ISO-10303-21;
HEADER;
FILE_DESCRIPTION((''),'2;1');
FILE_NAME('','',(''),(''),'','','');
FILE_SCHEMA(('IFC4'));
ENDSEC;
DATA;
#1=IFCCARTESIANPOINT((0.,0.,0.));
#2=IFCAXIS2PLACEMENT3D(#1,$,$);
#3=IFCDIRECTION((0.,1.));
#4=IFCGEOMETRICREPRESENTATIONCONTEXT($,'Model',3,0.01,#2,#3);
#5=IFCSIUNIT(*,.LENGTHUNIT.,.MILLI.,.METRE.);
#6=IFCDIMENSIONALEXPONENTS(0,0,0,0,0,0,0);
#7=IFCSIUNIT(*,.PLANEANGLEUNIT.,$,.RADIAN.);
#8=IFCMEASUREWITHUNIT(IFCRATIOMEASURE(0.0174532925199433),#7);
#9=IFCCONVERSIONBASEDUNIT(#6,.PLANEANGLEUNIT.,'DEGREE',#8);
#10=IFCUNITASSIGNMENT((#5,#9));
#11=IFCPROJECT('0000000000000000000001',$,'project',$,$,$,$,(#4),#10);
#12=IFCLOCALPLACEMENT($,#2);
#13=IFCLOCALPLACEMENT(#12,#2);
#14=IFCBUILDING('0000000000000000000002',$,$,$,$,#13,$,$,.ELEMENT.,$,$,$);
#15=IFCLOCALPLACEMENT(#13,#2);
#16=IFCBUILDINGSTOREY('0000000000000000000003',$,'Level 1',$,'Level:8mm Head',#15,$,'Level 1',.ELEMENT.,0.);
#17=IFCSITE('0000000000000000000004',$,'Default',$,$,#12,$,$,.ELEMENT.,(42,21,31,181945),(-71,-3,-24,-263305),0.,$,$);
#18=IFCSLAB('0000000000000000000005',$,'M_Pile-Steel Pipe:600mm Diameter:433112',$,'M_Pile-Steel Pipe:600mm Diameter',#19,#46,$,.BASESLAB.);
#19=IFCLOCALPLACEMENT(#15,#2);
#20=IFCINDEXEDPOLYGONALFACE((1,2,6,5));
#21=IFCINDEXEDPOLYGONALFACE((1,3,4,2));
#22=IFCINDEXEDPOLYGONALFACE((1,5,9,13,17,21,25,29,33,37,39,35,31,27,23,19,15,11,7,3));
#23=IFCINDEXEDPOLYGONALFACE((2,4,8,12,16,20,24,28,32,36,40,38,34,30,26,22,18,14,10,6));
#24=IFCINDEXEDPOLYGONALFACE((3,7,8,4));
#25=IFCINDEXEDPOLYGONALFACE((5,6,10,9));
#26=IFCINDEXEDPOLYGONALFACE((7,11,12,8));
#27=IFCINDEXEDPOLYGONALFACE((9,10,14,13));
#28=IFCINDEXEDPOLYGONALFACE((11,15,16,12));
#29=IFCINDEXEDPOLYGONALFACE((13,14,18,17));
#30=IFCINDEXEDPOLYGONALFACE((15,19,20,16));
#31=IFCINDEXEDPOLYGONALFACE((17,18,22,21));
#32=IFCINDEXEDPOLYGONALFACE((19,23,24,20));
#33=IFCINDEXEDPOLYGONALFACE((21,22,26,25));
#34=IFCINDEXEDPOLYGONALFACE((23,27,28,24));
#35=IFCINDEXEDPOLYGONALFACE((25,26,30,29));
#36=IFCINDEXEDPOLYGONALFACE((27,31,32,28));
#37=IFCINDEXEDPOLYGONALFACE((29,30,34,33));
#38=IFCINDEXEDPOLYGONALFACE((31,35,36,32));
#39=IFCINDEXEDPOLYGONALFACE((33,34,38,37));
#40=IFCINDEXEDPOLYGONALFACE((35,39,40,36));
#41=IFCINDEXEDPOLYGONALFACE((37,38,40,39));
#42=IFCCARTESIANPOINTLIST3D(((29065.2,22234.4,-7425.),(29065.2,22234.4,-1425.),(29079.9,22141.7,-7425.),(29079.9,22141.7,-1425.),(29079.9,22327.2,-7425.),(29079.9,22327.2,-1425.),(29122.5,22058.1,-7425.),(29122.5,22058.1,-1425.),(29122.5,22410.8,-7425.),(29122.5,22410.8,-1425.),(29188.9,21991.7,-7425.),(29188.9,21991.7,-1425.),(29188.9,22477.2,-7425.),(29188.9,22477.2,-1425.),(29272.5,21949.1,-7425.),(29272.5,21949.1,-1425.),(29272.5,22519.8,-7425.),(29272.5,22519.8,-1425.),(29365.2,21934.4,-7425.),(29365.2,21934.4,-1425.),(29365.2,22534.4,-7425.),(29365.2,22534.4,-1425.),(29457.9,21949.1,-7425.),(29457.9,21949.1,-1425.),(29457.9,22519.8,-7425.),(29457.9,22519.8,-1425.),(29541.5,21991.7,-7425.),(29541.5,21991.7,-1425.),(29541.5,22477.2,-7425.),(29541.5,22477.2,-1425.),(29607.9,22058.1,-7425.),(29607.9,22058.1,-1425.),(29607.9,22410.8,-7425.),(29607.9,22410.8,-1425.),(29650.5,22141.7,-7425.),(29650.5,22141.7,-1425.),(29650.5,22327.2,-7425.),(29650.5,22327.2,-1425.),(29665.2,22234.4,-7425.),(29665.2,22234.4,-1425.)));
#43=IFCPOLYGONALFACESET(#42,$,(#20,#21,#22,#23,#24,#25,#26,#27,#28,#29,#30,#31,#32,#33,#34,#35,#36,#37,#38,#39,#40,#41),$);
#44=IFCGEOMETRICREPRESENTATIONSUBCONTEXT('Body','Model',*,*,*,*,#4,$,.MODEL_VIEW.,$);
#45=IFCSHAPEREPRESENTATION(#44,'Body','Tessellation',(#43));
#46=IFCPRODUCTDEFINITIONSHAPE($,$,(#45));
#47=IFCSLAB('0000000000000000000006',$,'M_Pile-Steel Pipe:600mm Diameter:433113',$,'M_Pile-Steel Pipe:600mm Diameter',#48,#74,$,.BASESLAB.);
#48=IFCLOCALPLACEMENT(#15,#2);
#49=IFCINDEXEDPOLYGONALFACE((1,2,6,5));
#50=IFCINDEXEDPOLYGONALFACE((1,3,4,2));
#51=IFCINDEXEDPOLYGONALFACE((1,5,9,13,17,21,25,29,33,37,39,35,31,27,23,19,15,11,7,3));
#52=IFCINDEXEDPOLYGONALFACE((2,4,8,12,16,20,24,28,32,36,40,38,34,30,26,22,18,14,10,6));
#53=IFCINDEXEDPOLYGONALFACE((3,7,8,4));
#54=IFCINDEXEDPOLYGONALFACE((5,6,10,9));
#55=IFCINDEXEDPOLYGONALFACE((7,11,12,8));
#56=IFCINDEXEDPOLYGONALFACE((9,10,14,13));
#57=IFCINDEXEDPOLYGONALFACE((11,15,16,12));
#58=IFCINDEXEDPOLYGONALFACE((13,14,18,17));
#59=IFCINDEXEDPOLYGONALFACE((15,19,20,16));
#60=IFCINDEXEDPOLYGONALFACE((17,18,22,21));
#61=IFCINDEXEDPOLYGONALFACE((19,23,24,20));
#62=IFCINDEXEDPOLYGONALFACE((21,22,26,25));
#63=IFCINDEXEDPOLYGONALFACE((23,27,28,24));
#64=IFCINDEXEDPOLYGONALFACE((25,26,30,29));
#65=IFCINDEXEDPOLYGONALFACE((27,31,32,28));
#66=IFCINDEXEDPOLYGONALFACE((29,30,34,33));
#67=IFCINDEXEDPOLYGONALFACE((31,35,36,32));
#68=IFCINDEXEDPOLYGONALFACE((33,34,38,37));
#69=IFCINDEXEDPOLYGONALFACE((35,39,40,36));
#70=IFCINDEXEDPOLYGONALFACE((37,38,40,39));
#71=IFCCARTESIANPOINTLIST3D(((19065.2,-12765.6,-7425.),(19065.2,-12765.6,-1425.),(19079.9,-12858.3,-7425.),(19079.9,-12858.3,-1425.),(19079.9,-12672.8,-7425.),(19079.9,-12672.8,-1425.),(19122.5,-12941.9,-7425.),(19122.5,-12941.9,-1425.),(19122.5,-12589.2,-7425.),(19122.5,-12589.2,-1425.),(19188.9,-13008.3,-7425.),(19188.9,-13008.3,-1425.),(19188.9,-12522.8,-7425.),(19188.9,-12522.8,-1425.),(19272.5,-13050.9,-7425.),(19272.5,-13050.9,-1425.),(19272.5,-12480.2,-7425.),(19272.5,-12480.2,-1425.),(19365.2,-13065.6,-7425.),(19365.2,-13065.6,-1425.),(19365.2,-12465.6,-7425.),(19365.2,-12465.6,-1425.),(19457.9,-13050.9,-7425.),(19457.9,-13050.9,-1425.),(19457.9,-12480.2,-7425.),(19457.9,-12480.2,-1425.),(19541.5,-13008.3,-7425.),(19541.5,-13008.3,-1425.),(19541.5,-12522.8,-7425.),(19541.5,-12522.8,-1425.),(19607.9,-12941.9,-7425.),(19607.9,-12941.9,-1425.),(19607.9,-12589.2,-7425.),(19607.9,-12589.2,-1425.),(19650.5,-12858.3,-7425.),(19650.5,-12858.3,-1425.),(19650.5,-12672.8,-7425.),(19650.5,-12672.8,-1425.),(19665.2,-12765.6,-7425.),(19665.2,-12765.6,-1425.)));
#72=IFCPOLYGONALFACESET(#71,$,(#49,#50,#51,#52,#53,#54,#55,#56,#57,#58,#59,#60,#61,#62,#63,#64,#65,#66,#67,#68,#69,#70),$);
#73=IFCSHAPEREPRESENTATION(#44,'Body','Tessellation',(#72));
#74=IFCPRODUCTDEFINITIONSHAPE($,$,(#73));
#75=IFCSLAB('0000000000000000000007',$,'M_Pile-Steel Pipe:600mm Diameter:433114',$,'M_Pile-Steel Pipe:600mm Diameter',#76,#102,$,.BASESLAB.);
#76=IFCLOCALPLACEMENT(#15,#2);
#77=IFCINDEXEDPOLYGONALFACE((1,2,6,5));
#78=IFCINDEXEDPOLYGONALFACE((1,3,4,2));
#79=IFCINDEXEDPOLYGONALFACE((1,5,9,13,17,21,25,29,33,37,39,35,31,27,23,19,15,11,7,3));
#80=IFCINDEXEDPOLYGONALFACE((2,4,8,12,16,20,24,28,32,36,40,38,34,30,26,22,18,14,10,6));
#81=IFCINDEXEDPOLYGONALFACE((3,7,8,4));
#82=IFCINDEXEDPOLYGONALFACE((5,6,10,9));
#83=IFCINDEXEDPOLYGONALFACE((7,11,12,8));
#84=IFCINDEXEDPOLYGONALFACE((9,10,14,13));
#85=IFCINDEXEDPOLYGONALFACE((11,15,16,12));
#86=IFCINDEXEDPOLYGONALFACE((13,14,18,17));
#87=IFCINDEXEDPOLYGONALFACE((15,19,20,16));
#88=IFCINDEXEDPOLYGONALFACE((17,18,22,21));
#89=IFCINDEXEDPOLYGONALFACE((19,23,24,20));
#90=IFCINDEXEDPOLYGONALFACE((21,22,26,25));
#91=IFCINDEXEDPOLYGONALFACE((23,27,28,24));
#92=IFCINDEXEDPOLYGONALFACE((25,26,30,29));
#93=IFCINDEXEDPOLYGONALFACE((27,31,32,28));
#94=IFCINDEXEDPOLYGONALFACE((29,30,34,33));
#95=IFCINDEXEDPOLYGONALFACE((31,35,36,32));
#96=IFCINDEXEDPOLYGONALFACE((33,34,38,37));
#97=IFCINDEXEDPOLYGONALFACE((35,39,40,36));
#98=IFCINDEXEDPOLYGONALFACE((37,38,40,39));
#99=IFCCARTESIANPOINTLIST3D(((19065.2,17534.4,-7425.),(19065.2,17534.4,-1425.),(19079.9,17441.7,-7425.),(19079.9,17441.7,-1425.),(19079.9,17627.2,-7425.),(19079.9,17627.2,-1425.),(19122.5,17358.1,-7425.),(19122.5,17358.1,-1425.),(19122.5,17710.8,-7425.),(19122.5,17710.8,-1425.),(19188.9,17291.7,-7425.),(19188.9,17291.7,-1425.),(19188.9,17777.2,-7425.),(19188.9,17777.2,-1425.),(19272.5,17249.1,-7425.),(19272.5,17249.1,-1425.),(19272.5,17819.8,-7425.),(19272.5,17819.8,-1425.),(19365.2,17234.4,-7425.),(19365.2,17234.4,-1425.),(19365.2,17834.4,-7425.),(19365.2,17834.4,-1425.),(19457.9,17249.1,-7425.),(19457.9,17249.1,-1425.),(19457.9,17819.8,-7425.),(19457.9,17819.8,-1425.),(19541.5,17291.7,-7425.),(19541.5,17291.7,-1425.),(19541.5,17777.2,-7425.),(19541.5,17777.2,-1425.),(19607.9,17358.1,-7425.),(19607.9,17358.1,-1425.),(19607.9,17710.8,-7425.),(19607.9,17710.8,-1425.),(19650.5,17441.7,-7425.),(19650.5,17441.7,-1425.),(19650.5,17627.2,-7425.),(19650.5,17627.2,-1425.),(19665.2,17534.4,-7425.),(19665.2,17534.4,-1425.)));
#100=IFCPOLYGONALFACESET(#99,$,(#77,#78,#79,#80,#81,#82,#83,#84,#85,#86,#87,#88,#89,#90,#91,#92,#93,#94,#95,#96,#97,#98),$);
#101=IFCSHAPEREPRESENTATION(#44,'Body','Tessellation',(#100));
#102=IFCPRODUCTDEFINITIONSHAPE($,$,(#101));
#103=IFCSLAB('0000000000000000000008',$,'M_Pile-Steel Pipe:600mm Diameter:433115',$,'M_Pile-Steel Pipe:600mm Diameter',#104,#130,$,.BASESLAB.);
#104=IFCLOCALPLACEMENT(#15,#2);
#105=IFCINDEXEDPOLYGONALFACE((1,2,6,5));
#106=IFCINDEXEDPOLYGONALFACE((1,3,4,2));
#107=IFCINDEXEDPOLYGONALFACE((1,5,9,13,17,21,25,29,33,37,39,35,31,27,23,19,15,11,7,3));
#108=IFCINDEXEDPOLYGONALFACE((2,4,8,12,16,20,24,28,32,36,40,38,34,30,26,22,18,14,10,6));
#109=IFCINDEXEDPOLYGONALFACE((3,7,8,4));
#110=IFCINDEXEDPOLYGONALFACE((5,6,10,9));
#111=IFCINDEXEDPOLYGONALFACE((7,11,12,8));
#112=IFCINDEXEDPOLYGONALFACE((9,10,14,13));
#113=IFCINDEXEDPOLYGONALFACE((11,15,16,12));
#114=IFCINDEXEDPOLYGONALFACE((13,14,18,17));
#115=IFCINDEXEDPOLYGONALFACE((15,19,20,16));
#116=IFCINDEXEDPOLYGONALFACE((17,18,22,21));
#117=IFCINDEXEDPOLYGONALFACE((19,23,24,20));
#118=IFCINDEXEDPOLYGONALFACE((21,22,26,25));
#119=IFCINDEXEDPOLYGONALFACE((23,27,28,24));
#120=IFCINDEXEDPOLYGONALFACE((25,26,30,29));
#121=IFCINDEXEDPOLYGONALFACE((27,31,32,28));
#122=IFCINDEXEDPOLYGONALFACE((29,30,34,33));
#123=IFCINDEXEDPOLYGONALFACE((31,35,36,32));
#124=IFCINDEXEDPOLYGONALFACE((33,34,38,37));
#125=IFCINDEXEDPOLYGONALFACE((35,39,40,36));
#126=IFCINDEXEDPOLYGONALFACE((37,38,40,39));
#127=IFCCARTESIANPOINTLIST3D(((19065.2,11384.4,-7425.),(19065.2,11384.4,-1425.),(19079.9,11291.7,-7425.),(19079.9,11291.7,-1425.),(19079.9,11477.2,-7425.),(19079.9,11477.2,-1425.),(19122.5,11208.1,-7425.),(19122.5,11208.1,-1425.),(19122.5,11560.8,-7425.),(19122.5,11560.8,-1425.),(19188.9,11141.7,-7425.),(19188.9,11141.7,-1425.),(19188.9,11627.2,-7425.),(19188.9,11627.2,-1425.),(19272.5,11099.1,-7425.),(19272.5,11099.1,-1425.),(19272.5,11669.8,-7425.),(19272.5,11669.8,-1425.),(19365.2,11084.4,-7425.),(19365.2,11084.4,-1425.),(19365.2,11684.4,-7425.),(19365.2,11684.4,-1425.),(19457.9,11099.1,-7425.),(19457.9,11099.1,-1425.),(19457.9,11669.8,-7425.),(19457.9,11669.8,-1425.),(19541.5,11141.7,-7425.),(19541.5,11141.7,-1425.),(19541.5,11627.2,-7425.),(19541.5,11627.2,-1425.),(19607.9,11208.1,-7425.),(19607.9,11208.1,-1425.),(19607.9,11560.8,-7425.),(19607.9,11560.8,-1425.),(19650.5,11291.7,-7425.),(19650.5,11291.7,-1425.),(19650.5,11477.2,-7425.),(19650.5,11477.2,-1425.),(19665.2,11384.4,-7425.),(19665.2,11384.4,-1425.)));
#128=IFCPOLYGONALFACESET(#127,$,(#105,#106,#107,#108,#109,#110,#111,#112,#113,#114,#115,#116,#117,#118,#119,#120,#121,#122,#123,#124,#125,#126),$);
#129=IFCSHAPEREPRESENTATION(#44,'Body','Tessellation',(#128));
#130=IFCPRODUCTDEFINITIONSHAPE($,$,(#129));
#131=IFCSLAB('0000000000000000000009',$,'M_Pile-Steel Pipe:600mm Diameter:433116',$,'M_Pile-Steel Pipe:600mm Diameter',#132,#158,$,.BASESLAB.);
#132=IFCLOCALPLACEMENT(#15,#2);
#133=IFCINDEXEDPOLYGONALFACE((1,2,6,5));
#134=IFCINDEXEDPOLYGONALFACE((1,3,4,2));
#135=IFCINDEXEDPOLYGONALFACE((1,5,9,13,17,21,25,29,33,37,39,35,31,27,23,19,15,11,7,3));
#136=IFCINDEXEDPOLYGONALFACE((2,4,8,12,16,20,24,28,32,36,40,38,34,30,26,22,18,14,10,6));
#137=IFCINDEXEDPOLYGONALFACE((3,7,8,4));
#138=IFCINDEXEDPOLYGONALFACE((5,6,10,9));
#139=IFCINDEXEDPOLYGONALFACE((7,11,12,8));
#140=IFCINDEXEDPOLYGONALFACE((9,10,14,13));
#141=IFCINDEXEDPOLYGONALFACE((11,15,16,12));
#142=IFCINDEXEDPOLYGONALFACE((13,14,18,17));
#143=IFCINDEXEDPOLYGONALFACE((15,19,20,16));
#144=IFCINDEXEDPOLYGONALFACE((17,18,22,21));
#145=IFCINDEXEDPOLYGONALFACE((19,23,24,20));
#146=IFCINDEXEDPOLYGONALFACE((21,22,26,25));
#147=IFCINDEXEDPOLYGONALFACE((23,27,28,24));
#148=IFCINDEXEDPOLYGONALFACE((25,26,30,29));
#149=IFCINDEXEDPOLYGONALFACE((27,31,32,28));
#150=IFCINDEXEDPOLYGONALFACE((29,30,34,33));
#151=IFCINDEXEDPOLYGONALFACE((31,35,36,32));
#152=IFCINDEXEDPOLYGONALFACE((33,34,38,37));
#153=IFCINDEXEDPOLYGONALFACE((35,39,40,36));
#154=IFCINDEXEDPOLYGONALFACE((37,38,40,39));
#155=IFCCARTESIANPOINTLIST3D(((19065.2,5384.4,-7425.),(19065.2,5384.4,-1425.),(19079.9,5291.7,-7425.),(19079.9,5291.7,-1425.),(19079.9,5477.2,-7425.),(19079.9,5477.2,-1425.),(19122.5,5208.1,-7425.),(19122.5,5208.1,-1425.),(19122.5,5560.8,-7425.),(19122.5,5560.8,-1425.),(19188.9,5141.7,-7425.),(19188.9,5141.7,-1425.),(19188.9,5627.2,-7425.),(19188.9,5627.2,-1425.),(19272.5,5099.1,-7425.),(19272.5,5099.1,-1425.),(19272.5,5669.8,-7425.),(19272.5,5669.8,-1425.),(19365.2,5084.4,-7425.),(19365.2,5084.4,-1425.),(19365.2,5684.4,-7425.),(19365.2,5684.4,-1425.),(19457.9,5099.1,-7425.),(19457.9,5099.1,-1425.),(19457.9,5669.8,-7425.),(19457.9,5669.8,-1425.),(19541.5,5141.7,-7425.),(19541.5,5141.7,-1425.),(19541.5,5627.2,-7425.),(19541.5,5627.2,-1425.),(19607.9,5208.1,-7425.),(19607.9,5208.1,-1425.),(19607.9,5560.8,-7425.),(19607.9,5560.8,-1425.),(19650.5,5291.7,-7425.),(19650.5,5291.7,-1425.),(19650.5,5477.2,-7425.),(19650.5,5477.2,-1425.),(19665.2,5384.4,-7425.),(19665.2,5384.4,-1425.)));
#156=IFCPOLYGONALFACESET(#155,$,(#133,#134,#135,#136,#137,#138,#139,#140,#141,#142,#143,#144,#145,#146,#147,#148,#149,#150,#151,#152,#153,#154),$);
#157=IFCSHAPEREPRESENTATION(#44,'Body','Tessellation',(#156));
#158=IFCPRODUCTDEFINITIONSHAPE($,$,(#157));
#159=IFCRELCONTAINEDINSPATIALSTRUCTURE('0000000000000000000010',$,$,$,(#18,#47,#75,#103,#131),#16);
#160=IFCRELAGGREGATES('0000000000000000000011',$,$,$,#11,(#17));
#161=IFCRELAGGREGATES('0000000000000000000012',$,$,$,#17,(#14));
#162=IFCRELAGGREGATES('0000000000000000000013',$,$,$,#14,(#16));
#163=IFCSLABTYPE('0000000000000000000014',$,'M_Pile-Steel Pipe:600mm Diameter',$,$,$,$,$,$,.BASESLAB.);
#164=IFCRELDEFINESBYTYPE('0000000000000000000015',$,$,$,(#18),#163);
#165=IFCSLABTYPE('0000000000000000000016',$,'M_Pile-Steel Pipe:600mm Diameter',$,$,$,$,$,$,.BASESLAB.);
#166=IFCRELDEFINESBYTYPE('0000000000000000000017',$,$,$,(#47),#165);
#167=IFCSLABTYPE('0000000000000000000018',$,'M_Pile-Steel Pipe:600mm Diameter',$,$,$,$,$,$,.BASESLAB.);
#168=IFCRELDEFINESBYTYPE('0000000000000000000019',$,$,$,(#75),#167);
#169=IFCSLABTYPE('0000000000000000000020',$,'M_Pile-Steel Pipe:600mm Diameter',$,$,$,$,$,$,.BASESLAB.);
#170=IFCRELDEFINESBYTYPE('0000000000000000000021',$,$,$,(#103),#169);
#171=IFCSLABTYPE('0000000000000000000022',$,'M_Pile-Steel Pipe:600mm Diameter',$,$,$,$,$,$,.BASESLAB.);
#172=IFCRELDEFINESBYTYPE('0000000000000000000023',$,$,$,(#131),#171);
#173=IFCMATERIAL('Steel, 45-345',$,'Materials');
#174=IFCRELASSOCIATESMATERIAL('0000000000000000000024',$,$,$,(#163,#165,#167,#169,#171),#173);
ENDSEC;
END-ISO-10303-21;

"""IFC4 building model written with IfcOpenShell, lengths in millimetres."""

from ifc_helpers import new_model, entity, si_unit, converted_unit, direction, frame, origin, place, context, subcontext, project, spatial, indexed_curve, outline, extrude, material, type_object, element, save


model = new_model("IFC4")

# Units and contexts
model_context = context("Model", 3, precision=0.01, world=origin(), true_north=direction((0.0, 1.0)))
body_context = subcontext(model_context, "Body", "Model", "MODEL_VIEW")
ifc_project = project(units=[si_unit("LENGTHUNIT", "METRE", prefix="MILLI"), converted_unit("PLANEANGLEUNIT", "DEGREE", entity("IfcRatioMeasure", 0.0174532925199433), si_unit("PLANEANGLEUNIT", "RADIAN"), dimensions=[0, 0, 0, 0, 0, 0, 0])], contexts=[model_context])

# Site, building, storey
site_placement = place(None, origin())
site = spatial("IfcSite", under=ifc_project, at=site_placement, Name="Default", CompositionType="ELEMENT", RefLatitude=(42, 21, 31, 181945), RefLongitude=(-71, -3, -24, -263305), RefElevation=0.0)
building_placement = place(site_placement, origin())
building = spatial("IfcBuilding", under=site, at=building_placement, CompositionType="ELEMENT")
storey_placement = place(building_placement, origin())
storey = spatial("IfcBuildingStorey", under=building, at=storey_placement, Name="Level 1", ObjectType="Level:8mm Head", LongName="Level 1", CompositionType="ELEMENT", Elevation=0.0)

# Slabs
ifc_material_1 = material(Name="Steel, 45-345", Category="Materials")
slab_type_1 = type_object("IfcSlabType", Name="M_Pile-Steel Pipe:600mm Diameter", PredefinedType="BASESLAB", material=ifc_material_1)
slab_1_placement = place(building_placement, origin())
element("IfcSlab", 1, at=slab_1_placement, inside=storey, type_object=slab_type_1, Name="M_Pile-Steel Pipe:600mm Diameter:433112", ObjectType="M_Pile-Steel Pipe:600mm Diameter", PredefinedType="BASESLAB", context=body_context, shape_type="SweptSolid", body=[
    extrude(outline(indexed_curve([(300.0, 0.0), (285.3, 92.7), (242.7, 176.3), (176.3, 242.7), (92.7, 285.3), (0.0, 300.0), (-92.7, 285.3), (-176.3, 242.7), (-242.7, 176.3), (-285.3, 92.7), (-300.0, 0.0), (-285.3, -92.7), (-242.7, -176.3), (-176.3, -242.7), (-92.7, -285.3), (0.0, -300.0), (92.7, -285.3), (176.3, -242.7), (242.7, -176.3), (285.3, -92.7), (300.0, 0.0)], self_intersect=False)), frame((29365.2, 22234.4, -7425.0)), (0.0, 0.0, 1.0), 6000.0),
])
slab_type_2 = type_object("IfcSlabType", Name="M_Pile-Steel Pipe:600mm Diameter", PredefinedType="BASESLAB", material=ifc_material_1)
slab_2_placement = place(building_placement, origin())
element("IfcSlab", 2, at=slab_2_placement, inside=storey, type_object=slab_type_2, Name="M_Pile-Steel Pipe:600mm Diameter:433113", ObjectType="M_Pile-Steel Pipe:600mm Diameter", PredefinedType="BASESLAB", context=body_context, shape_type="SweptSolid", body=[
    extrude(outline(indexed_curve([(300.0, 0.0), (285.3, 92.7), (242.7, 176.3), (176.3, 242.7), (92.7, 285.3), (0.0, 300.0), (-92.7, 285.3), (-176.3, 242.7), (-242.7, 176.3), (-285.3, 92.7), (-300.0, 0.0), (-285.3, -92.7), (-242.7, -176.3), (-176.3, -242.7), (-92.7, -285.3), (0.0, -300.0), (92.7, -285.3), (176.3, -242.7), (242.7, -176.3), (285.3, -92.7), (300.0, 0.0)], self_intersect=False)), frame((19365.2, -12765.6, -7425.0)), (0.0, 0.0, 1.0), 6000.0),
])
slab_type_3 = type_object("IfcSlabType", Name="M_Pile-Steel Pipe:600mm Diameter", PredefinedType="BASESLAB", material=ifc_material_1)
slab_3_placement = place(building_placement, origin())
element("IfcSlab", 3, at=slab_3_placement, inside=storey, type_object=slab_type_3, Name="M_Pile-Steel Pipe:600mm Diameter:433114", ObjectType="M_Pile-Steel Pipe:600mm Diameter", PredefinedType="BASESLAB", context=body_context, shape_type="SweptSolid", body=[
    extrude(outline(indexed_curve([(300.0, 0.0), (285.3, 92.7), (242.7, 176.3), (176.3, 242.7), (92.7, 285.3), (0.0, 300.0), (-92.7, 285.3), (-176.3, 242.7), (-242.7, 176.3), (-285.3, 92.7), (-300.0, 0.0), (-285.3, -92.7), (-242.7, -176.3), (-176.3, -242.7), (-92.7, -285.3), (0.0, -300.0), (92.7, -285.3), (176.3, -242.7), (242.7, -176.3), (285.3, -92.7), (300.0, 0.0)], self_intersect=False)), frame((19365.2, 17534.4, -7425.0)), (0.0, 0.0, 1.0), 6000.0),
])
slab_type_4 = type_object("IfcSlabType", Name="M_Pile-Steel Pipe:600mm Diameter", PredefinedType="BASESLAB", material=ifc_material_1)
slab_4_placement = place(building_placement, origin())
element("IfcSlab", 4, at=slab_4_placement, inside=storey, type_object=slab_type_4, Name="M_Pile-Steel Pipe:600mm Diameter:433115", ObjectType="M_Pile-Steel Pipe:600mm Diameter", PredefinedType="BASESLAB", context=body_context, shape_type="SweptSolid", body=[
    extrude(outline(indexed_curve([(300.0, 0.0), (285.3, 92.7), (242.7, 176.3), (176.3, 242.7), (92.7, 285.3), (0.0, 300.0), (-92.7, 285.3), (-176.3, 242.7), (-242.7, 176.3), (-285.3, 92.7), (-300.0, 0.0), (-285.3, -92.7), (-242.7, -176.3), (-176.3, -242.7), (-92.7, -285.3), (0.0, -300.0), (92.7, -285.3), (176.3, -242.7), (242.7, -176.3), (285.3, -92.7), (300.0, 0.0)], self_intersect=False)), frame((19365.2, 11384.4, -7425.0)), (0.0, 0.0, 1.0), 6000.0),
])
slab_type_5 = type_object("IfcSlabType", Name="M_Pile-Steel Pipe:600mm Diameter", PredefinedType="BASESLAB", material=ifc_material_1)
slab_5_placement = place(building_placement, origin())
element("IfcSlab", 5, at=slab_5_placement, inside=storey, type_object=slab_type_5, Name="M_Pile-Steel Pipe:600mm Diameter:433116", ObjectType="M_Pile-Steel Pipe:600mm Diameter", PredefinedType="BASESLAB", context=body_context, shape_type="SweptSolid", body=[
    extrude(outline(indexed_curve([(300.0, 0.0), (285.3, 92.7), (242.7, 176.3), (176.3, 242.7), (92.7, 285.3), (0.0, 300.0), (-92.7, 285.3), (-176.3, 242.7), (-242.7, 176.3), (-285.3, 92.7), (-300.0, 0.0), (-285.3, -92.7), (-242.7, -176.3), (-176.3, -242.7), (-92.7, -285.3), (0.0, -300.0), (92.7, -285.3), (176.3, -242.7), (242.7, -176.3), (285.3, -92.7), (300.0, 0.0)], self_intersect=False)), frame((19365.2, 5384.4, -7425.0)), (0.0, 0.0, 1.0), 6000.0),
])

save(model, "model.ifc")
